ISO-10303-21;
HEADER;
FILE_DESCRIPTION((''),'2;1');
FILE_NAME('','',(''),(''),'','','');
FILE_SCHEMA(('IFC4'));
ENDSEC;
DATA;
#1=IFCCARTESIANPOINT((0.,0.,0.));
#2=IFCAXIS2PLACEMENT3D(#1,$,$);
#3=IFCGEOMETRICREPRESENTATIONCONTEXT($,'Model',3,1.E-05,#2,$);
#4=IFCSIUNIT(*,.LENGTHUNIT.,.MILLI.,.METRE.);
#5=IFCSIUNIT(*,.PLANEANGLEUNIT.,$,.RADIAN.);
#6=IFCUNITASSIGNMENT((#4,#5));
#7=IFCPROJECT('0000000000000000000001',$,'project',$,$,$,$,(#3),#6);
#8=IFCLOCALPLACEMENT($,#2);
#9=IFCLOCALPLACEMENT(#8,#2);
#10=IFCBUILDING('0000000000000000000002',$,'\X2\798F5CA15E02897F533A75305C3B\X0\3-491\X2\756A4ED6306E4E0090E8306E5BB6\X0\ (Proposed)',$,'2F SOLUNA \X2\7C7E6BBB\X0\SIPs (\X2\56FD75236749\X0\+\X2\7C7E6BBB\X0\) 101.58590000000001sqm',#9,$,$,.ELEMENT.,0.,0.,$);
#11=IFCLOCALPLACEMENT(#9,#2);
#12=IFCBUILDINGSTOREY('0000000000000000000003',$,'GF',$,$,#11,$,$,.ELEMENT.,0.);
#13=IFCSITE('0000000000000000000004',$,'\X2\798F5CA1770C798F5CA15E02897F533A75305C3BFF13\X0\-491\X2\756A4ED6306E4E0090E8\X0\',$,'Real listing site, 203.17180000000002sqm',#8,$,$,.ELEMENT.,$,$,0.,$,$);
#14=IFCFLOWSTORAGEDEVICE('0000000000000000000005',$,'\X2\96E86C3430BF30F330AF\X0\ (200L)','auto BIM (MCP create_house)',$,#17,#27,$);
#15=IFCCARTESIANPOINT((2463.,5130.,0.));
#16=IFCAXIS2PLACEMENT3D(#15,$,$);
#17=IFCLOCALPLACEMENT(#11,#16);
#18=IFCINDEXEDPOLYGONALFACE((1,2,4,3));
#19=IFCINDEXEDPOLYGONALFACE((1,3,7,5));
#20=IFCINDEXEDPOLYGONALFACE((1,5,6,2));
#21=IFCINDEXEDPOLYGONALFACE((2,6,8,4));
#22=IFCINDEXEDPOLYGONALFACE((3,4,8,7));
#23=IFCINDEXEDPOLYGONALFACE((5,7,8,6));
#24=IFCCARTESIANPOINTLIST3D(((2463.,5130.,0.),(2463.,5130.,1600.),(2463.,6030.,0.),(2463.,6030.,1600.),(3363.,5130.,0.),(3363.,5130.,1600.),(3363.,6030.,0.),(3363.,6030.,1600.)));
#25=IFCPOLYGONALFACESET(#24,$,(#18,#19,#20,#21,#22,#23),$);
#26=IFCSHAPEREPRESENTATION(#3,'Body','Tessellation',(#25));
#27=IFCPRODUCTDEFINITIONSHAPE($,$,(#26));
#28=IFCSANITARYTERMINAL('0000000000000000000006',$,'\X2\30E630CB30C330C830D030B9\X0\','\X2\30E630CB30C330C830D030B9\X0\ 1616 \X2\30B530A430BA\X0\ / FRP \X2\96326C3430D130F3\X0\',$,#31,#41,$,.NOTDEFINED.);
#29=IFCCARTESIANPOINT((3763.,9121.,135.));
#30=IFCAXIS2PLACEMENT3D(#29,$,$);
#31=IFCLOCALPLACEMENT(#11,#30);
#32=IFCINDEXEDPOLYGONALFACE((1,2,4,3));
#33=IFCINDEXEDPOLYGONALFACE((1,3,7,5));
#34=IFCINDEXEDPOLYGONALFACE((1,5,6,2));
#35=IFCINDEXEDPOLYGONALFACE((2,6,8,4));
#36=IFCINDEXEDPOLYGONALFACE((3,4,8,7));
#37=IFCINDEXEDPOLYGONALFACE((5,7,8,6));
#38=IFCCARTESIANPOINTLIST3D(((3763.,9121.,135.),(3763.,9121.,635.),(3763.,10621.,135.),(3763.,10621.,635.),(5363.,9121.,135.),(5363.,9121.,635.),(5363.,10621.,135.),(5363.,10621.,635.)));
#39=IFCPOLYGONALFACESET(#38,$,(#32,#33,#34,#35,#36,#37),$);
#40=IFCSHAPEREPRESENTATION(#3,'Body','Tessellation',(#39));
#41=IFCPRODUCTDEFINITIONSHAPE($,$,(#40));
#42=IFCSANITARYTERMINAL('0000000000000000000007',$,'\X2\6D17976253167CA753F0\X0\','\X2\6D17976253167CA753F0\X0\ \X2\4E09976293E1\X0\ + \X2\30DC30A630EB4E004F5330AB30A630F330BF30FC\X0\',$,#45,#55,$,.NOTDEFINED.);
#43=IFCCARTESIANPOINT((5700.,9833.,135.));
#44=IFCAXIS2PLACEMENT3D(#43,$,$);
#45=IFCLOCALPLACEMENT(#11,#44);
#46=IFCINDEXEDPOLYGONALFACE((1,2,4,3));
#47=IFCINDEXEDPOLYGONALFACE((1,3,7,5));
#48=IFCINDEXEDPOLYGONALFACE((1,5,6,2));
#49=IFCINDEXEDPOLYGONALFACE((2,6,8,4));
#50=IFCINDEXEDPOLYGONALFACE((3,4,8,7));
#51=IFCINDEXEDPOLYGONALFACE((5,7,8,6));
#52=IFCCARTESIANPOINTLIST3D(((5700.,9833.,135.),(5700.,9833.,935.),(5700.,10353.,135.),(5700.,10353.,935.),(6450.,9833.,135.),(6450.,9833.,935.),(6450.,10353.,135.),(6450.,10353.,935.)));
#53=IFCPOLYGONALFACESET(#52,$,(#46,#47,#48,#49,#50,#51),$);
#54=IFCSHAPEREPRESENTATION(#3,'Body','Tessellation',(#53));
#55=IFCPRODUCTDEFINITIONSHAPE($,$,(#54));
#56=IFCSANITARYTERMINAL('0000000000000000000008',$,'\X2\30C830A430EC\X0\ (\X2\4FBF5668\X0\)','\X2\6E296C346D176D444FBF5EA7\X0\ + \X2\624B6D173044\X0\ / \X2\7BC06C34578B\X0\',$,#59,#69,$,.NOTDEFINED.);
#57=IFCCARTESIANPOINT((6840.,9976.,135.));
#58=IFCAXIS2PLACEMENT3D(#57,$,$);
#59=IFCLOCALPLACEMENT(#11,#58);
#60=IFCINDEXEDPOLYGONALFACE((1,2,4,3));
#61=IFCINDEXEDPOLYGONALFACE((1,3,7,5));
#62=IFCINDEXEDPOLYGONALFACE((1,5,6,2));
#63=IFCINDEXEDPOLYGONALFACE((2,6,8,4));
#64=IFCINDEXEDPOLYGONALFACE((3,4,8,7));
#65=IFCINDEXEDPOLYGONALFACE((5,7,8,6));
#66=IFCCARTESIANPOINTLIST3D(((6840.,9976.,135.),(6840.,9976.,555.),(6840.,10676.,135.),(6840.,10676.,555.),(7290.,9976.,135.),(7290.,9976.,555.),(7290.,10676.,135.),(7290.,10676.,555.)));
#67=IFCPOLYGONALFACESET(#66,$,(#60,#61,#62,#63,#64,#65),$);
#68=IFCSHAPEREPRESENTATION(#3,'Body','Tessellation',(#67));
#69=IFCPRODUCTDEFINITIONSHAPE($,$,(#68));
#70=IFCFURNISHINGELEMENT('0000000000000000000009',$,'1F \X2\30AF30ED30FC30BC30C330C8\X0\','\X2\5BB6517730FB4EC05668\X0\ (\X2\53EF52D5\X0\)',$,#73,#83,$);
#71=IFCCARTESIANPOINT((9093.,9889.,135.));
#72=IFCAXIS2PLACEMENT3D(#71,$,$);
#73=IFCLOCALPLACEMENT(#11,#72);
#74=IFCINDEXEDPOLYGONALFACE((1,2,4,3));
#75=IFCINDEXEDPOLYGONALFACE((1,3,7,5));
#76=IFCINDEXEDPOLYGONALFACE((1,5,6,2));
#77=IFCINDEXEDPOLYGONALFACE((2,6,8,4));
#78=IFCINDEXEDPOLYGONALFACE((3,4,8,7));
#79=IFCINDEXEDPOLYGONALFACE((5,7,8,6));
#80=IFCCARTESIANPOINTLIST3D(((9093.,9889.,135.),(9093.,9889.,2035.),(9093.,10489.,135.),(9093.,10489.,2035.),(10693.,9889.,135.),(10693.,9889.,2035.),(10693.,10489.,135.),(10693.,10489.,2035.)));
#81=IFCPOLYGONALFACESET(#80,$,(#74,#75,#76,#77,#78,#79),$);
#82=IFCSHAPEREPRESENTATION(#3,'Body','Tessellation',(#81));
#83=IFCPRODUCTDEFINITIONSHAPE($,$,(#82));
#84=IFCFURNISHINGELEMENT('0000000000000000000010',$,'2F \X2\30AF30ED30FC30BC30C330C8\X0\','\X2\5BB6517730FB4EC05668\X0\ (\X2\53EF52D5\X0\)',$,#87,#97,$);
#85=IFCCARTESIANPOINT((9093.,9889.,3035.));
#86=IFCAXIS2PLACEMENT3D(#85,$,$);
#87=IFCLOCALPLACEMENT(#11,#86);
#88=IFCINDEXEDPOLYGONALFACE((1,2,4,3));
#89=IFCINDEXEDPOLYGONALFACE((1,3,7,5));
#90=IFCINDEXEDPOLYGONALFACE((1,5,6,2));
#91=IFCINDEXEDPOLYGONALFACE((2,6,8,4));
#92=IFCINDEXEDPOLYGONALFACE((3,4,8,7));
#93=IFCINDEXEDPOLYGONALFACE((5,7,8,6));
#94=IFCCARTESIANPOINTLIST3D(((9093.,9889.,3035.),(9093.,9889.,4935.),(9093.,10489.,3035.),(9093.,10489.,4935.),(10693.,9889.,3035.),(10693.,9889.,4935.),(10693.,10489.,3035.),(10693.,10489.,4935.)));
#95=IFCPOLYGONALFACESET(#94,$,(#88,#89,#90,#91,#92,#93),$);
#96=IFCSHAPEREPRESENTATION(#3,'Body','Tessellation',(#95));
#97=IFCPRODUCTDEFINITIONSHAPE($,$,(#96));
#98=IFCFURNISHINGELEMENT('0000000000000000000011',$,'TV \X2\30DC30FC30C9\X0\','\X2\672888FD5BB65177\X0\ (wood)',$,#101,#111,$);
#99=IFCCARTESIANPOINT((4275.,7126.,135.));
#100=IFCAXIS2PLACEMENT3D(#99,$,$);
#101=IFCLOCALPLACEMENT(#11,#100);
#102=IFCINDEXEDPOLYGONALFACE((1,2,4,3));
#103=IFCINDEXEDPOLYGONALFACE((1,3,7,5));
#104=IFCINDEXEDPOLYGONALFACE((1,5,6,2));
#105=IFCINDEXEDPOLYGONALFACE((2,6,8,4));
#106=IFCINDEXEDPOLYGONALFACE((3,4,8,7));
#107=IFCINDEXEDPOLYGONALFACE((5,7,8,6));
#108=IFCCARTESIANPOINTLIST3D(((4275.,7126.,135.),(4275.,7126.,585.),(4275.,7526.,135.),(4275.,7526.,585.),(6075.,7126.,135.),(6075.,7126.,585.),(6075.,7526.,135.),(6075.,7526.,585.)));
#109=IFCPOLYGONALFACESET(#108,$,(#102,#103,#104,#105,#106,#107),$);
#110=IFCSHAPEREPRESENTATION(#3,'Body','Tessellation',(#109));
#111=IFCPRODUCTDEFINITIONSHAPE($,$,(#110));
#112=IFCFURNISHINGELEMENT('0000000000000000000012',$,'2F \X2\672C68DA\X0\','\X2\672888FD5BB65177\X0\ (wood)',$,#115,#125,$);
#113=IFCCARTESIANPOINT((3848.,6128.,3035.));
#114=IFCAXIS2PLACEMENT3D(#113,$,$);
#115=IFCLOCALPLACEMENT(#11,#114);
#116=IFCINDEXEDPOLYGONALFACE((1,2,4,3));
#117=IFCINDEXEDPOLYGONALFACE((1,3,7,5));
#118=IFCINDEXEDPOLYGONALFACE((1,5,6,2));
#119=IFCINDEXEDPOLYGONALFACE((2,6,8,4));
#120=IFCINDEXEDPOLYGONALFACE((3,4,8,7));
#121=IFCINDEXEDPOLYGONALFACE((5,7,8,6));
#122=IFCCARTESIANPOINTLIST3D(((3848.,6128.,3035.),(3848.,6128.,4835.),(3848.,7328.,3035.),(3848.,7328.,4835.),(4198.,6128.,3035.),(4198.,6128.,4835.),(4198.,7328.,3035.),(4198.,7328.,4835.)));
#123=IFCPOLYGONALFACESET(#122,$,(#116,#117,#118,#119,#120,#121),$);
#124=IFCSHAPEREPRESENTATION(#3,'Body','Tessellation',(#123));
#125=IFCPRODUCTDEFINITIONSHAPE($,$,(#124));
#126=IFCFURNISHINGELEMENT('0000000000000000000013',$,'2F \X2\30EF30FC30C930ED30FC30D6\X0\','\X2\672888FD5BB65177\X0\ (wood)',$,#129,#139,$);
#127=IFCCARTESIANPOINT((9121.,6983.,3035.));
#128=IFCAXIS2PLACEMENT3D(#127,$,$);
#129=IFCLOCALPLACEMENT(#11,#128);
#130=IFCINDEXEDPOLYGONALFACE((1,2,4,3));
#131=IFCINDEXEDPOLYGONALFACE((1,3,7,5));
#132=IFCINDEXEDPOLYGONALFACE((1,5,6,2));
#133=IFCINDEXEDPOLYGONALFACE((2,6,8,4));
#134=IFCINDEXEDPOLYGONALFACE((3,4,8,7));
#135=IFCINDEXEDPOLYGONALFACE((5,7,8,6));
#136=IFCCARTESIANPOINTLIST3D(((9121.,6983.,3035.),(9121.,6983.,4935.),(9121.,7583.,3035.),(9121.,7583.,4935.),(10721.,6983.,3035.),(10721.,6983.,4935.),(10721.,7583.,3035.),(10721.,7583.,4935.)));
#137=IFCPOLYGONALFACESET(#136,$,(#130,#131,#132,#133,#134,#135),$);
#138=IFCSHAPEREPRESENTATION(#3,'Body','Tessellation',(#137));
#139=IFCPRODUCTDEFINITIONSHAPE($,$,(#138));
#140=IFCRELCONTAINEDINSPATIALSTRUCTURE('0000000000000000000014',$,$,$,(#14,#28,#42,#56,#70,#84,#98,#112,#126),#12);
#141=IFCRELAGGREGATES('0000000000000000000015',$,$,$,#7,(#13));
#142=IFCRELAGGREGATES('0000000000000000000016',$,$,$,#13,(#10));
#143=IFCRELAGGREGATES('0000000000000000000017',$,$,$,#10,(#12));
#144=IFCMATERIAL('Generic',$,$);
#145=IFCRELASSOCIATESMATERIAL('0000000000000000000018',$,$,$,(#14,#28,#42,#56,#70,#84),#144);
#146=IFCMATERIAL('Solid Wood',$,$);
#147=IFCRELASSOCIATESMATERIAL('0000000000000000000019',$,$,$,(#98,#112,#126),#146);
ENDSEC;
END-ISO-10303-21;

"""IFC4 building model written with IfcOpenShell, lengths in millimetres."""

from ifc_helpers import new_model, si_unit, frame, frame_2d, origin, place, context, project, spatial, rectangle, extrude, material, element, save


model = new_model("IFC4")

# Units and contexts
model_context = context("Model", 3, precision=1e-05, world=origin())
ifc_project = project(units=[si_unit("LENGTHUNIT", "METRE", prefix="MILLI"), si_unit("PLANEANGLEUNIT", "RADIAN")], contexts=[model_context])

# Site, building, storey
site_placement = place(None, origin())
site = spatial("IfcSite", under=ifc_project, at=site_placement, Name="福岡県福岡市西区田尻３-491番他の一部", ObjectType="Real listing site, 203.17180000000002sqm", CompositionType="ELEMENT", RefElevation=0.0)
building_placement = place(site_placement, origin())
building = spatial("IfcBuilding", under=site, at=building_placement, Name="福岡市西区田尻3-491番他の一部の家 (Proposed)", ObjectType="2F SOLUNA 籾殻SIPs (国産杉+籾殻) 101.58590000000001sqm", CompositionType="ELEMENT", ElevationOfRefHeight=0.0, ElevationOfTerrain=0.0)
storey_placement = place(building_placement, origin())
storey = spatial("IfcBuildingStorey", under=building, at=storey_placement, Name="GF", CompositionType="ELEMENT", Elevation=0.0)

# Shared definitions
ifc_material_1 = material(Name="Solid Wood")

# Flow storage device
ifc_material_2 = material(Name="Generic")
flow_storage_device_placement = place(storey_placement, frame((2463.0, 5130.0, 0.0)))
element("IfcFlowStorageDevice", 1, at=flow_storage_device_placement, inside=storey, material=ifc_material_2, Name="雨水タンク (200L)", Description="auto BIM (MCP create_house)", context=model_context, shape_type="SweptSolid", body=[
    extrude(rectangle(XDim=900.0, YDim=900.0, at=frame_2d((450.0, 450.0))), frame((2463.0, 5130.0, 0.0)), (0.0, 0.0, 1.0), 1600.0),
])

# Sanitary terminals
sanitary_terminal_1_placement = place(storey_placement, frame((3763.0, 9121.0, 135.0)))
element("IfcSanitaryTerminal", 2, at=sanitary_terminal_1_placement, inside=storey, material=ifc_material_2, Name="ユニットバス", Description="ユニットバス 1616 サイズ / FRP 防水パン", PredefinedType="NOTDEFINED", context=model_context, shape_type="SweptSolid", body=[
    extrude(rectangle(XDim=1600.0, YDim=1500.0, at=frame_2d((800.0, 750.0))), frame((3763.0, 9121.0, 135.0)), (0.0, 0.0, 1.0), 500.0),
])
sanitary_terminal_2_placement = place(storey_placement, frame((5700.0, 9833.0, 135.0)))
element("IfcSanitaryTerminal", 3, at=sanitary_terminal_2_placement, inside=storey, material=ifc_material_2, Name="洗面化粧台", Description="洗面化粧台 三面鏡 + ボウル一体カウンター", PredefinedType="NOTDEFINED", context=model_context, shape_type="SweptSolid", body=[
    extrude(rectangle(XDim=750.0, YDim=520.0, at=frame_2d((375.0, 260.0))), frame((5700.0, 9833.0, 135.0)), (0.0, 0.0, 1.0), 800.0),
])
sanitary_terminal_3_placement = place(storey_placement, frame((6840.0, 9976.0, 135.0)))
element("IfcSanitaryTerminal", 4, at=sanitary_terminal_3_placement, inside=storey, material=ifc_material_2, Name="トイレ (便器)", Description="温水洗浄便座 + 手洗い / 節水型", PredefinedType="NOTDEFINED", context=model_context, shape_type="SweptSolid", body=[
    extrude(rectangle(XDim=450.0, YDim=700.0, at=frame_2d((225.0, 350.0))), frame((6840.0, 9976.0, 135.0)), (0.0, 0.0, 1.0), 420.0),
])

# Furnishing elements
furnishing_1_placement = place(storey_placement, frame((9093.0, 9889.0, 135.0)))
element("IfcFurnishingElement", 5, at=furnishing_1_placement, inside=storey, material=ifc_material_2, Name="1F クローゼット", Description="家具・什器 (可動)", context=model_context, shape_type="SweptSolid", body=[
    extrude(rectangle(XDim=1600.0, YDim=600.0, at=frame_2d((800.0, 300.0))), frame((9093.0, 9889.0, 135.0)), (0.0, 0.0, 1.0), 1900.0),
])
furnishing_2_placement = place(storey_placement, frame((9093.0, 9889.0, 3035.0)))
element("IfcFurnishingElement", 6, at=furnishing_2_placement, inside=storey, material=ifc_material_2, Name="2F クローゼット", Description="家具・什器 (可動)", context=model_context, shape_type="SweptSolid", body=[
    extrude(rectangle(XDim=1600.0, YDim=600.0, at=frame_2d((800.0, 300.0))), frame((9093.0, 9889.0, 3035.0)), (0.0, 0.0, 1.0), 1900.0),
])
furnishing_3_placement = place(storey_placement, frame((4275.0, 7126.0, 135.0)))
element("IfcFurnishingElement", 7, at=furnishing_3_placement, inside=storey, material=ifc_material_1, Name="TV ボード", Description="木製家具 (wood)", context=model_context, shape_type="SweptSolid", body=[
    extrude(rectangle(XDim=1800.0, YDim=400.0, at=frame_2d((900.0, 200.0))), frame((4275.0, 7126.0, 135.0)), (0.0, 0.0, 1.0), 450.0),
])
furnishing_4_placement = place(storey_placement, frame((3848.0, 6128.0, 3035.0)))
element("IfcFurnishingElement", 8, at=furnishing_4_placement, inside=storey, material=ifc_material_1, Name="2F 本棚", Description="木製家具 (wood)", context=model_context, shape_type="SweptSolid", body=[
    extrude(rectangle(XDim=350.0, YDim=1200.0, at=frame_2d((175.0, 600.0))), frame((3848.0, 6128.0, 3035.0)), (0.0, 0.0, 1.0), 1800.0),
])
furnishing_5_placement = place(storey_placement, frame((9121.0, 6983.0, 3035.0)))
element("IfcFurnishingElement", 9, at=furnishing_5_placement, inside=storey, material=ifc_material_1, Name="2F ワードローブ", Description="木製家具 (wood)", context=model_context, shape_type="SweptSolid", body=[
    extrude(rectangle(XDim=1600.0, YDim=600.0, at=frame_2d((800.0, 300.0))), frame((9121.0, 6983.0, 3035.0)), (0.0, 0.0, 1.0), 1900.0),
])

save(model, "model.ifc")
